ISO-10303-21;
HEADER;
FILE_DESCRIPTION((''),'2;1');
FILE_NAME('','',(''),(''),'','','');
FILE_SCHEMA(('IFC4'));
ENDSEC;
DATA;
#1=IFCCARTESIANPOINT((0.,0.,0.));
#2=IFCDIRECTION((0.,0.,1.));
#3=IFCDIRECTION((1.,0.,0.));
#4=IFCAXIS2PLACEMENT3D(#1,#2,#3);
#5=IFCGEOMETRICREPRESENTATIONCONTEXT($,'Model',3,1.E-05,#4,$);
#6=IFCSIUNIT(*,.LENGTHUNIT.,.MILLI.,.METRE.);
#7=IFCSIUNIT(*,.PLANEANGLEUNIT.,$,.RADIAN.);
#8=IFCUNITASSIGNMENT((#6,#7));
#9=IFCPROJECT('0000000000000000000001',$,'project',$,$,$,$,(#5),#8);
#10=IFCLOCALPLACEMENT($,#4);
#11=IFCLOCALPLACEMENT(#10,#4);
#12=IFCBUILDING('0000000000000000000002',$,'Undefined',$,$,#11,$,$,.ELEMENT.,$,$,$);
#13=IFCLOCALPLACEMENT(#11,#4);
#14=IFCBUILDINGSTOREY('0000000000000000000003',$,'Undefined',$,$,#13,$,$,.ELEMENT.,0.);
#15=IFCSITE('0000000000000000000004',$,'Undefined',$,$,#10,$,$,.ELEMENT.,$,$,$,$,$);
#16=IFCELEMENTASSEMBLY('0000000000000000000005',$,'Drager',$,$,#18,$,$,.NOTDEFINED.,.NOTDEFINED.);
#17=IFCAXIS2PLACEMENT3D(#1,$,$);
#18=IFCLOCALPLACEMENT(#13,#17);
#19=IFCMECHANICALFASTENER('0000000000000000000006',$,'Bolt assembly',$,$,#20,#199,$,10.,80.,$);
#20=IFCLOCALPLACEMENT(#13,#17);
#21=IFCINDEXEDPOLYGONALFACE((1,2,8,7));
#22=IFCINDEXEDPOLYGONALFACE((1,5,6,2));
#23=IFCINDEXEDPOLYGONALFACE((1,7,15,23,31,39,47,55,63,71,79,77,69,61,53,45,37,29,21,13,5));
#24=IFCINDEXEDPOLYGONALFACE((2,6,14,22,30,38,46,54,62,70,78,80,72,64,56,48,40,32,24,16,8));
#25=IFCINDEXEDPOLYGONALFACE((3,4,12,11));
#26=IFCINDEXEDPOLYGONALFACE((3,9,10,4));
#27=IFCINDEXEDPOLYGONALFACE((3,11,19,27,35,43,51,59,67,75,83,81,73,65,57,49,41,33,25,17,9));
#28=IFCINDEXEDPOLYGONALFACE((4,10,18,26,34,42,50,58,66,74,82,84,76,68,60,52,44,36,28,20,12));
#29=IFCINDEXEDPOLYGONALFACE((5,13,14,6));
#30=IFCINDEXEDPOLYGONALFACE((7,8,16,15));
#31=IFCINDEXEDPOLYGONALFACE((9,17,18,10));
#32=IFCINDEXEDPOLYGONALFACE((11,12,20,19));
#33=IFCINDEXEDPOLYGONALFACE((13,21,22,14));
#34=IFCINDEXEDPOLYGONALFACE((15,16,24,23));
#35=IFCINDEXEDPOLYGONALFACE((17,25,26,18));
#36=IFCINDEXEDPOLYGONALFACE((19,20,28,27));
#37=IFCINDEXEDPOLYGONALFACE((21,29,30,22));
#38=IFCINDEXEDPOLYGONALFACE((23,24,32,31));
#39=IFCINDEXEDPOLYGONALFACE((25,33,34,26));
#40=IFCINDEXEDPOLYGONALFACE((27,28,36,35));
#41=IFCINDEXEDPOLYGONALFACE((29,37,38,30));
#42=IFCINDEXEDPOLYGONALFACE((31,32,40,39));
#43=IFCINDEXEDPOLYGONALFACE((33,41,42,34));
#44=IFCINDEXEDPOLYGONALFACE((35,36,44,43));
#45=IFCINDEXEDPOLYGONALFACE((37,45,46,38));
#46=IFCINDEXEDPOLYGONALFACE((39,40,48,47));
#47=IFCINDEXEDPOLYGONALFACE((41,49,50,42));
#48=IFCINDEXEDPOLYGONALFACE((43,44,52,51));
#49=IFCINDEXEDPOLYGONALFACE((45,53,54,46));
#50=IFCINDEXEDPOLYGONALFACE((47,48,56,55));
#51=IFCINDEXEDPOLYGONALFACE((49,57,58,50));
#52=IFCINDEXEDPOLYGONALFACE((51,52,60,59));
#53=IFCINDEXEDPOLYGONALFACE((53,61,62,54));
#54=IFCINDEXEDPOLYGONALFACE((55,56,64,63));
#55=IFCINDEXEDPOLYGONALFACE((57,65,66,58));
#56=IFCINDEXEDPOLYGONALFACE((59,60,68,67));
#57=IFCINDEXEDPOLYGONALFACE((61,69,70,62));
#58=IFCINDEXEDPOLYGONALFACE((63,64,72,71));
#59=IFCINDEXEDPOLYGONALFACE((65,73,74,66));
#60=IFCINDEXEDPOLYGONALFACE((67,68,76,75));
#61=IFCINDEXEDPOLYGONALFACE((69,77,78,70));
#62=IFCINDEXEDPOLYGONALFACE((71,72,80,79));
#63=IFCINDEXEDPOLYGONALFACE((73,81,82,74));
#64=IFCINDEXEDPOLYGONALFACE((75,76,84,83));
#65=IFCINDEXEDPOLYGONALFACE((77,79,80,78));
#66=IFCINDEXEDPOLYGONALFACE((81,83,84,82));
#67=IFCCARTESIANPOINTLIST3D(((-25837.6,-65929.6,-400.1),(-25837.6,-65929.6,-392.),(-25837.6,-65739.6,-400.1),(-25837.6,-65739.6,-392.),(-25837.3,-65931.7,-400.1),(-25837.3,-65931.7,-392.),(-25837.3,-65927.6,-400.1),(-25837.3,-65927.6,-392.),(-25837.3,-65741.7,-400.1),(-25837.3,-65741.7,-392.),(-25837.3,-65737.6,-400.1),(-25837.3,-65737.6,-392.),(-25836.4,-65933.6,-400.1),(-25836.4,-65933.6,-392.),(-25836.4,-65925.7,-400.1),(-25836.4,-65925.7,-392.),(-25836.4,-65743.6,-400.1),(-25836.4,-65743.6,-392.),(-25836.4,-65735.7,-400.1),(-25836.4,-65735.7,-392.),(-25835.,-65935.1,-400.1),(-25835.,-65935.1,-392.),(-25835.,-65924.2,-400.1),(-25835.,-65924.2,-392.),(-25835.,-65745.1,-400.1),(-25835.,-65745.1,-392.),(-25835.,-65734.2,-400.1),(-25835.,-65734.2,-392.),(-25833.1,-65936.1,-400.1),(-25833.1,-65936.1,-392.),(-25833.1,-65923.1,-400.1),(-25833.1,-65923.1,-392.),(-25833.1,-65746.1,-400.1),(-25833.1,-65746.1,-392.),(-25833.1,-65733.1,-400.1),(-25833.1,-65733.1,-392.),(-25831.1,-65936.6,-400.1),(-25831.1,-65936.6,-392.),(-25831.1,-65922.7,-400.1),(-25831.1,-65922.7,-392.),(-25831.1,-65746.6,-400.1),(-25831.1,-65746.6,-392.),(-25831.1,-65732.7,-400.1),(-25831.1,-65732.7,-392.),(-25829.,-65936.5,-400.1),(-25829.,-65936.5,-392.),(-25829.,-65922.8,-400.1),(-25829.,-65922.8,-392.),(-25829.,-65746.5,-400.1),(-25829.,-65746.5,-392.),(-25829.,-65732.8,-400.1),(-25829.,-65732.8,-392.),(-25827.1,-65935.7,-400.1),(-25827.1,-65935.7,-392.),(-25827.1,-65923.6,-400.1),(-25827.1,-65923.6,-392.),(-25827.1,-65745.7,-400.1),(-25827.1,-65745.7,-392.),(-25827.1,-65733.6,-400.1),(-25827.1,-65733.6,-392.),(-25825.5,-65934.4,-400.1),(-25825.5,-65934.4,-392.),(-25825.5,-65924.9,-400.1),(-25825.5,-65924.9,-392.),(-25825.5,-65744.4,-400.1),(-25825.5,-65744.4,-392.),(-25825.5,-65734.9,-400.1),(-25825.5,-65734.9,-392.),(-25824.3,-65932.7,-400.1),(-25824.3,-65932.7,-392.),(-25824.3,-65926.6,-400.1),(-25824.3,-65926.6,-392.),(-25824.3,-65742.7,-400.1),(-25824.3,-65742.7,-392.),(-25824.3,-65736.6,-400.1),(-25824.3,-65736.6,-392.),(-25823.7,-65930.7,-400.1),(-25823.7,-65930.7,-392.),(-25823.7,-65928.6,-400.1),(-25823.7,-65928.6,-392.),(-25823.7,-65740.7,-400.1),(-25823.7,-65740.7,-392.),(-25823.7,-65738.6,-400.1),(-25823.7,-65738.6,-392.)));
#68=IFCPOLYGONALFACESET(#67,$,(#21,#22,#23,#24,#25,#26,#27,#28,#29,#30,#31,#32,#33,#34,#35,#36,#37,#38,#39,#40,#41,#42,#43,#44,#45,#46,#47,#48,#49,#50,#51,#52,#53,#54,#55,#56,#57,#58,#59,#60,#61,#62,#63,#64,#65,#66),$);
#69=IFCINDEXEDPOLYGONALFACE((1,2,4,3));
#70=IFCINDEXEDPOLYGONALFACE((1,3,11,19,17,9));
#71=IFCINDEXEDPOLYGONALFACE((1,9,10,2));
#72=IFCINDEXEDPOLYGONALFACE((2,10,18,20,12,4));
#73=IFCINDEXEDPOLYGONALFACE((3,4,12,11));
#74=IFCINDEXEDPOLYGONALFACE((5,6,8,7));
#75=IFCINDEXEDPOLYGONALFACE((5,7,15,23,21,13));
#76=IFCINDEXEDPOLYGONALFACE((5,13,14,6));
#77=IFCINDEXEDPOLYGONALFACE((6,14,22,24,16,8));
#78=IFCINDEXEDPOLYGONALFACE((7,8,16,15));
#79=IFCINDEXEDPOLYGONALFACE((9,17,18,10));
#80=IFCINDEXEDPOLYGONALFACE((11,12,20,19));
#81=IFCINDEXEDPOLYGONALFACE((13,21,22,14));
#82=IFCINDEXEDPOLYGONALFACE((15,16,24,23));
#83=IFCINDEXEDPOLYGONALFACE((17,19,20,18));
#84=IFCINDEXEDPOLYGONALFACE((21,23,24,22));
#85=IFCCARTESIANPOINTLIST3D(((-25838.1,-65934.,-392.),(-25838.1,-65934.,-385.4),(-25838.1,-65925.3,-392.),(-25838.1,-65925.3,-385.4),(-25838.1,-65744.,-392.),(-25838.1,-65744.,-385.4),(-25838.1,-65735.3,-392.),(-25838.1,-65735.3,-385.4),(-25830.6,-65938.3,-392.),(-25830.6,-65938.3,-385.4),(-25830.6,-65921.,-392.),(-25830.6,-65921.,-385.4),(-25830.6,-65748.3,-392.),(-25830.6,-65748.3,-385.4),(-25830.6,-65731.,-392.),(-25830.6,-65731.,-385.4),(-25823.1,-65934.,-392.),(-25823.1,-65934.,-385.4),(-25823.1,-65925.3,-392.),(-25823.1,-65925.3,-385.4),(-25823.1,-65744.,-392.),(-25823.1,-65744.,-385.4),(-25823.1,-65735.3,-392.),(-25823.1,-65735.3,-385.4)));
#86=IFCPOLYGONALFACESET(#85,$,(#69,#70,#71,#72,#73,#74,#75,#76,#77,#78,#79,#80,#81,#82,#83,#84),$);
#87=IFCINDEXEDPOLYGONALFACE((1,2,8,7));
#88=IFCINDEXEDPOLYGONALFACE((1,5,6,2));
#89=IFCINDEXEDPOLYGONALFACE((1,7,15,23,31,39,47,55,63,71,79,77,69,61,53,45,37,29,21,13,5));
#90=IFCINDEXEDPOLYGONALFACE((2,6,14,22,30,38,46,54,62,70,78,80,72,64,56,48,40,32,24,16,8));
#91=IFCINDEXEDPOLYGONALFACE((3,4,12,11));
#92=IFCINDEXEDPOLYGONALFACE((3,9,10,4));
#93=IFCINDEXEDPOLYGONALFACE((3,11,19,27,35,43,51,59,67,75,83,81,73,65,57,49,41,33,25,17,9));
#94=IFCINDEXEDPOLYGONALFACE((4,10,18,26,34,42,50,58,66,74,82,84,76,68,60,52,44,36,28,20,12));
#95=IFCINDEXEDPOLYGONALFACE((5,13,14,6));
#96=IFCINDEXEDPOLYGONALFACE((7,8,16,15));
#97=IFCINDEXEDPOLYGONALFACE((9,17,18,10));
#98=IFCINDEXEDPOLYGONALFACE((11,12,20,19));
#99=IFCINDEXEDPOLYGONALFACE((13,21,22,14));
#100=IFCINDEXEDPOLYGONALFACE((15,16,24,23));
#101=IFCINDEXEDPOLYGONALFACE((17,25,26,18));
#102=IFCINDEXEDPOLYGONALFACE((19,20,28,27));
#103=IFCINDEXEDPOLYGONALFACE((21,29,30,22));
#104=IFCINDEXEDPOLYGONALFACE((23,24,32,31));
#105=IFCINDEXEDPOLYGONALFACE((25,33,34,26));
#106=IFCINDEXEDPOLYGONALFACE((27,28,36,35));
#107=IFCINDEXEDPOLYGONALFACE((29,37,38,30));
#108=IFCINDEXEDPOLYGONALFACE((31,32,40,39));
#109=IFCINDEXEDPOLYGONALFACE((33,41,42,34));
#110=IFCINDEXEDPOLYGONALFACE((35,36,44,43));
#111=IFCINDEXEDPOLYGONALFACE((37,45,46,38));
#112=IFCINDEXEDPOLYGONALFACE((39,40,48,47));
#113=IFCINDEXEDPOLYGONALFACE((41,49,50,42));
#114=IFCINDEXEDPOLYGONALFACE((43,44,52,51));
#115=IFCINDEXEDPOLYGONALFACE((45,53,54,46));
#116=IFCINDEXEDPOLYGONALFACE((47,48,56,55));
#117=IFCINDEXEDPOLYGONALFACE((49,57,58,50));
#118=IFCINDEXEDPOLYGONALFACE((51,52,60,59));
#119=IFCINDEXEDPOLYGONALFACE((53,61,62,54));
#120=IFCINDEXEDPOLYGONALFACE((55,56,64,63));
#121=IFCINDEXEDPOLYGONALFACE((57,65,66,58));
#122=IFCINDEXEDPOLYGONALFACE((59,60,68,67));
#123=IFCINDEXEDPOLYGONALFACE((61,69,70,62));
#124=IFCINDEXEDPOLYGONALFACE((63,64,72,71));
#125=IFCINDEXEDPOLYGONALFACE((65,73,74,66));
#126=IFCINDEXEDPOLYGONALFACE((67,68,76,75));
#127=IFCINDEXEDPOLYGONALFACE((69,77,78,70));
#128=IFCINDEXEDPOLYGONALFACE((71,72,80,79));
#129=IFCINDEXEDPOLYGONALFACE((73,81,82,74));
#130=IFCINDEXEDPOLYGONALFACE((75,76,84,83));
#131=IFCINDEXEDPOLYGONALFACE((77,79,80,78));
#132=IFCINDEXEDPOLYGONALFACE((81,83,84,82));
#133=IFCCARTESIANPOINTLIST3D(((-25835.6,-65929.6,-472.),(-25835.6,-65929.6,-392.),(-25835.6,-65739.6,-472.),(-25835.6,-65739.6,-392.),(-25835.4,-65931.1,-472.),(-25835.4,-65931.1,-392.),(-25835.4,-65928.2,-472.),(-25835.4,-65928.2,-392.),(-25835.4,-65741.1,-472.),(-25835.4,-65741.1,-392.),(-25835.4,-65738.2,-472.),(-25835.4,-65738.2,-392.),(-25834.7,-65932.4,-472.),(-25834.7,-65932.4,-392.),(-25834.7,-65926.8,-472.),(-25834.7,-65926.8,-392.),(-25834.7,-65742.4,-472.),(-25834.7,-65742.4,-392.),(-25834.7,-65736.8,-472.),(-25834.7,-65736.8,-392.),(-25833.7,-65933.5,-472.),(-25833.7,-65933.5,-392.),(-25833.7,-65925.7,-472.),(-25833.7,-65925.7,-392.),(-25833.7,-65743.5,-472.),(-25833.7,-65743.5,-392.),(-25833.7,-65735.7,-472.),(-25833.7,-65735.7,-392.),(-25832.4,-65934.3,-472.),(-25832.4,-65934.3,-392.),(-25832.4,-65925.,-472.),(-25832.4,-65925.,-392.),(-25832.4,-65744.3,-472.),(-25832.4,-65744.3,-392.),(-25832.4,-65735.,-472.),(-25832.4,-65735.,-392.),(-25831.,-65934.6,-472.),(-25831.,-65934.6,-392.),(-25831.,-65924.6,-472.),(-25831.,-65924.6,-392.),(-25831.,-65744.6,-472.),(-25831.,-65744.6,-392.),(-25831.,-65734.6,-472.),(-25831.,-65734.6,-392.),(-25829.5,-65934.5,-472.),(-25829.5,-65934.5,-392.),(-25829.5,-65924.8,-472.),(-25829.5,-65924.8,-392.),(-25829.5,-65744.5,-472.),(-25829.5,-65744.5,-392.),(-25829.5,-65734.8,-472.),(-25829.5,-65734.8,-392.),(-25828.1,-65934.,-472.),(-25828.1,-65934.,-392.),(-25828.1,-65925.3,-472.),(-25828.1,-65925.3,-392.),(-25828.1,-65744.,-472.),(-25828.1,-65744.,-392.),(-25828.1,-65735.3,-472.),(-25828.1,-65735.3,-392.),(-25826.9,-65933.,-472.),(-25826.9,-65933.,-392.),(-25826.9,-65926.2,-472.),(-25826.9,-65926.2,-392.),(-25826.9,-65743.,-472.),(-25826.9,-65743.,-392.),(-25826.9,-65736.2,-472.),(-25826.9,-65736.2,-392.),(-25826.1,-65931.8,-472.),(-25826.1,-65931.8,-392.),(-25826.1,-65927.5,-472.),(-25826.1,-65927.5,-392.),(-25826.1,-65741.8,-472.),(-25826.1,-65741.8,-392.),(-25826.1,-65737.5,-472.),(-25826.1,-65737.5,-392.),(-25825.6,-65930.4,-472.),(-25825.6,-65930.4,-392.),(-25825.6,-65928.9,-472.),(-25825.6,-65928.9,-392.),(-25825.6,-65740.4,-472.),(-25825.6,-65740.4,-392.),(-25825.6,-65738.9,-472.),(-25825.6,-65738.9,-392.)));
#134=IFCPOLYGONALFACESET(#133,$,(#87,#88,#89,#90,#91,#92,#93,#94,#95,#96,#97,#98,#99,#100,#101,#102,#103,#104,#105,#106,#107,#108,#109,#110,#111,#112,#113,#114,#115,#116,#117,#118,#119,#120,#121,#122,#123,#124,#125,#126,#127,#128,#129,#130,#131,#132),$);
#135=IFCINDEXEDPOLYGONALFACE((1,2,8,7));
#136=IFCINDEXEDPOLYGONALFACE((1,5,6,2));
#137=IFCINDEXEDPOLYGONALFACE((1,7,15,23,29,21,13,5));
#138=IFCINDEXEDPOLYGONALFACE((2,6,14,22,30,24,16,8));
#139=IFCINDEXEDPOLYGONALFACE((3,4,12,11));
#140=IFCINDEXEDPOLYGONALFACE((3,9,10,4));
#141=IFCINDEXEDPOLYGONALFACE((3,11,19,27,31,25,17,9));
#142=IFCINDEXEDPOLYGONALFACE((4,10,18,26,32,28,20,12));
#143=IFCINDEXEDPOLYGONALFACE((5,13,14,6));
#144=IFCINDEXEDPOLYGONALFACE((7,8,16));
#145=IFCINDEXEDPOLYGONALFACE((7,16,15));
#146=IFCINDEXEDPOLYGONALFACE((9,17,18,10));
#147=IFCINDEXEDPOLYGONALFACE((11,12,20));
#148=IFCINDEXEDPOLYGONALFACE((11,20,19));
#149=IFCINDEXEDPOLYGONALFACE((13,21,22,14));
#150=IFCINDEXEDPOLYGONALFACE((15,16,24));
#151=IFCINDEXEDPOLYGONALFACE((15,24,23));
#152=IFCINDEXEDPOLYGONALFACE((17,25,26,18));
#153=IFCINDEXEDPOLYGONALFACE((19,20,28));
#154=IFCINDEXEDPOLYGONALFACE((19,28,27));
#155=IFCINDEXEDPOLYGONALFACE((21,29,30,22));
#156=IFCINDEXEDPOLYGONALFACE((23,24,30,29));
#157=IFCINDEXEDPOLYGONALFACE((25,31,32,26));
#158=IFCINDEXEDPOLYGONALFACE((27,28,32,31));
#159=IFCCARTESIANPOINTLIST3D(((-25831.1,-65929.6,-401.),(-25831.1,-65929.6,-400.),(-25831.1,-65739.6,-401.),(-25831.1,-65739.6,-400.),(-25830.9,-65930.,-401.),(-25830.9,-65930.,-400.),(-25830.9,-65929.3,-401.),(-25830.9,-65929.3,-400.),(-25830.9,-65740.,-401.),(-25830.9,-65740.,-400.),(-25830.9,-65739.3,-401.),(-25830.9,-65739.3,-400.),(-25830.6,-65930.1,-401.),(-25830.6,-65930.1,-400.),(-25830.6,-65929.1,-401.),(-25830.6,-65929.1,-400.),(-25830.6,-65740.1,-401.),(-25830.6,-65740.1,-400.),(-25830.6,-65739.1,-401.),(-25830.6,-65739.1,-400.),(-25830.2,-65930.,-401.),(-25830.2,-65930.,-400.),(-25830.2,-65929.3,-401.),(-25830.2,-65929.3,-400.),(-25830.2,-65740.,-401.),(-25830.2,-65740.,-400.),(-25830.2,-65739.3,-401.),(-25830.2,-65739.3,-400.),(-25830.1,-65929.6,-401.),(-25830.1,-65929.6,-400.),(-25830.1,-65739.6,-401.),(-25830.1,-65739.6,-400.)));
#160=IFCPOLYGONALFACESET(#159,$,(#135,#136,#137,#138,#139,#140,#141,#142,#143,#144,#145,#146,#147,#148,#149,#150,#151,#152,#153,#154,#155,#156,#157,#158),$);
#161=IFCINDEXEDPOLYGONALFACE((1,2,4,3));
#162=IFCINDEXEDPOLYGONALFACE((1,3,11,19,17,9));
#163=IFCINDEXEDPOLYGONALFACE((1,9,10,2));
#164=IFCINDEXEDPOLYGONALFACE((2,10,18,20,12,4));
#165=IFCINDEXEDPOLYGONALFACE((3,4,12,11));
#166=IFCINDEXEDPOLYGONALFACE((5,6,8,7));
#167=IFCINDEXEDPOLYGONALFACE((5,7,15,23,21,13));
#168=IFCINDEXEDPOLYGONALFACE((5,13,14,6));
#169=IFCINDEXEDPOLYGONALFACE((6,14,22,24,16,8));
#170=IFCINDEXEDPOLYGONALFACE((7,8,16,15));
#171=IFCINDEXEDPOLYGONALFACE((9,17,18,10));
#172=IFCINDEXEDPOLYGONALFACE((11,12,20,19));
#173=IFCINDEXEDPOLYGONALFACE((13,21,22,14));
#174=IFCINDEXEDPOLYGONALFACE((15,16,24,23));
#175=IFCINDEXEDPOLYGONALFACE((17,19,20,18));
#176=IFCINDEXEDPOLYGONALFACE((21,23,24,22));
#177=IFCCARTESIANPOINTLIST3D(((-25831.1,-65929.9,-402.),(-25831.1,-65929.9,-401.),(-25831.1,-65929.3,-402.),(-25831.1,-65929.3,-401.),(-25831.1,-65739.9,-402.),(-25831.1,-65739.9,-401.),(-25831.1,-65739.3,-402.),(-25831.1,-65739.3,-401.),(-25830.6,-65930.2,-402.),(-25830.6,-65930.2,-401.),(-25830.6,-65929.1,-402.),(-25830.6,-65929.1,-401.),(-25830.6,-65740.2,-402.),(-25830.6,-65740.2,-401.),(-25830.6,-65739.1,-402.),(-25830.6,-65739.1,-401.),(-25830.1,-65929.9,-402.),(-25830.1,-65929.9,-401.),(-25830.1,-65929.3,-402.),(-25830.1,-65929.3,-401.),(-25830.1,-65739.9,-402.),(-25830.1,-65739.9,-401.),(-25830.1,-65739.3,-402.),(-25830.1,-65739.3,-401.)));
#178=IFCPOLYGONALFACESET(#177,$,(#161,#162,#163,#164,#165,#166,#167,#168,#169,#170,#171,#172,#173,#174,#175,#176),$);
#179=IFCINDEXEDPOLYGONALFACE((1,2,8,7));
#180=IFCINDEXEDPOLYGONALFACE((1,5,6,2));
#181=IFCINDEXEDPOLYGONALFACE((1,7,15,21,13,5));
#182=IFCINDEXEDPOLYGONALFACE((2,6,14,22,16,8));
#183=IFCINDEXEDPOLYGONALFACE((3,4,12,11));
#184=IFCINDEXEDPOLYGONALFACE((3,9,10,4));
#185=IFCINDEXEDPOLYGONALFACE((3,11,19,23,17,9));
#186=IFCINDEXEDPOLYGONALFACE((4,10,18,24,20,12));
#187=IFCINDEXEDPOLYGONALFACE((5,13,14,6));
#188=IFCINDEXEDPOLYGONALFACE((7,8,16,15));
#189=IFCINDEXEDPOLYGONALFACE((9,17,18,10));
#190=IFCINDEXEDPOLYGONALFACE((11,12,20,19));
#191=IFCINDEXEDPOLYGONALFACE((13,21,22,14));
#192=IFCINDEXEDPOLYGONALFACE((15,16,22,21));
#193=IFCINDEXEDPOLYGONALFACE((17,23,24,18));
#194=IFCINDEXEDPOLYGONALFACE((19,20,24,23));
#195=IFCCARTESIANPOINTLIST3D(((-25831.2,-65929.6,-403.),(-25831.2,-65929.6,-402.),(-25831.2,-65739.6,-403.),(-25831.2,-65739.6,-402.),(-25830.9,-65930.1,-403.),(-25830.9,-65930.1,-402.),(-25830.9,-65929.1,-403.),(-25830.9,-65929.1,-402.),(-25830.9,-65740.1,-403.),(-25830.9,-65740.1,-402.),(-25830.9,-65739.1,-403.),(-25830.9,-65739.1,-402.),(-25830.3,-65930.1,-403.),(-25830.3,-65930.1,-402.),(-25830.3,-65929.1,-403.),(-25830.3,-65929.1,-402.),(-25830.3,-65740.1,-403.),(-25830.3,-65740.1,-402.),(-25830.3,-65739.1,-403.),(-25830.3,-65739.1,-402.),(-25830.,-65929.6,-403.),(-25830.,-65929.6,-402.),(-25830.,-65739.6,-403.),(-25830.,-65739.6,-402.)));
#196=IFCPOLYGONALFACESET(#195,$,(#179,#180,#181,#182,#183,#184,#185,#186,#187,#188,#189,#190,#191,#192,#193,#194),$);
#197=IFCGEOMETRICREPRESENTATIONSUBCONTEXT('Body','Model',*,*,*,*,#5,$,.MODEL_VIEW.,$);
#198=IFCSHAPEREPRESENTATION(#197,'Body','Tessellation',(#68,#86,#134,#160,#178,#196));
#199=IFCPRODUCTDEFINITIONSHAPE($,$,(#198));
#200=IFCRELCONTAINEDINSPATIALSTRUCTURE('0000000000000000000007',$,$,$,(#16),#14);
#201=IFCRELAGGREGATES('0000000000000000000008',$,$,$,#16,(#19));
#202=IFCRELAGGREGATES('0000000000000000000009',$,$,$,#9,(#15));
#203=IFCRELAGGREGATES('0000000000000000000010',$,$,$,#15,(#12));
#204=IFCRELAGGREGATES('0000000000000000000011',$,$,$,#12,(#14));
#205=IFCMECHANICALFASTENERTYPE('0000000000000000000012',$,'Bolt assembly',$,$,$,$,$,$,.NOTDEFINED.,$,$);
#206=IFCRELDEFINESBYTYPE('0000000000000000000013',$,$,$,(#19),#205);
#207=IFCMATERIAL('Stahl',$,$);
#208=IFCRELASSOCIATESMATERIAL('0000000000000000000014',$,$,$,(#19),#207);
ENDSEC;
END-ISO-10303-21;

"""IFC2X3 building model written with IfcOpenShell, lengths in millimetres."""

from ifc_helpers import new_model, si_unit, frame, origin_with_axes, origin_2d_with_axis, place, context, subcontext, project, spatial, polyline, circle, outline, extrude, source, transform, mapped, material, type_object, element, aggregate, save


model = new_model("IFC2X3")

# Units and contexts
model_context = context("Model", 3, precision=1e-05, world=origin_with_axes())
body_context = subcontext(model_context, "Body", "Model", "MODEL_VIEW")
ifc_project = project(units=[si_unit("LENGTHUNIT", "METRE", prefix="MILLI"), si_unit("PLANEANGLEUNIT", "RADIAN")], contexts=[model_context])

# Site, building, storey
site_placement = place(None, origin_with_axes())
site = spatial("IfcSite", under=ifc_project, at=site_placement, Name="Undefined", CompositionType="ELEMENT")
building_placement = place(site_placement, origin_with_axes())
building = spatial("IfcBuilding", under=site, at=building_placement, Name="Undefined", CompositionType="ELEMENT")
storey_placement = place(building_placement, origin_with_axes())
storey = spatial("IfcBuildingStorey", under=building, at=storey_placement, Name="Undefined", CompositionType="ELEMENT", Elevation=0.0)

# Element assembly
assembly_1_placement = place(storey_placement, origin_with_axes())
assembly_1 = element("IfcElementAssembly", 1, at=assembly_1_placement, inside=storey, Name="Drager", AssemblyPlace="NOTDEFINED", PredefinedType="NOTDEFINED")

# Mechanical fastener
mechanical_fastener_type = type_object("IfcMechanicalFastenerType", Name="Bolt assembly")
ifc_material_1 = material(Name="Stahl")
shared_shape_1 = source(origin_with_axes(), body_context, "Body", "SweptSolid", [
    extrude(circle(Radius=7.0, at=origin_2d_with_axis()), frame((0.0, 0.0, 0.0), z_axis=(0.0, 1.0, 0.0), x_axis=(1.0, 0.0, 0.0)), (0.0, 0.0, 1.0), 8.1),
    extrude(outline(polyline([(7.5, -4.3), (7.5, 4.3), (0.0, 8.7), (-7.5, 4.3), (-7.5, -4.3), (0.0, -8.7), (7.5, -4.3)])), frame((0.0, -6.6, 0.0), z_axis=(0.0, 1.0, 0.0), x_axis=(1.0, 0.0, 0.0)), (0.0, 0.0, 1.0), 6.6),
    extrude(circle(Radius=5.0, at=origin_2d_with_axis()), frame((0.0, 0.0, 0.0), z_axis=(0.0, 1.0, 0.0), x_axis=(1.0, 0.0, 0.0)), (0.0, 0.0, 1.0), 80.0),
    extrude(circle(Radius=0.5, at=origin_2d_with_axis()), frame((0.0, 8.0, 0.0), z_axis=(0.0, 1.0, 0.0), x_axis=(1.0, 0.0, 0.0)), (0.0, 0.0, 1.0), 1.0),
    extrude(outline(polyline([(0.5, -0.3), (0.5, 0.3), (0.0, 0.6), (-0.5, 0.3), (-0.5, -0.3), (0.0, -0.6), (0.5, -0.3)])), frame((0.0, 9.0, 0.0), z_axis=(0.0, 1.0, 0.0), x_axis=(1.0, 0.0, 0.0)), (0.0, 0.0, 1.0), 1.0),
    extrude(outline(polyline([(0.6, 0.0), (0.3, 0.5), (-0.3, 0.5), (-0.6, 0.0), (-0.3, -0.5), (0.3, -0.5), (0.6, 0.0)])), frame((0.0, 10.0, 0.0), z_axis=(0.0, 1.0, 0.0), x_axis=(1.0, 0.0, 0.0)), (0.0, 0.0, 1.0), 1.0),
])
mechanical_fastener_1_placement = place(assembly_1_placement, frame((-25830.6, -65834.6, -392.0), z_axis=(0.0, -1.0, 0.0), x_axis=(-1.0, 0.0, 0.0)))
mechanical_fastener_1 = element("IfcMechanicalFastener", 2, at=mechanical_fastener_1_placement, type_object=mechanical_fastener_type, material=ifc_material_1, Name="Bolt assembly", NominalDiameter=10.0, NominalLength=80.0, context=body_context, shape_type="MappedRepresentation", body=[
    mapped(shared_shape_1, transform((0.0, 0.0, -95.0))),
    mapped(shared_shape_1, transform((0.0, 0.0, 95.0))),
])
aggregate(assembly_1, [mechanical_fastener_1])

save(model, "model.ifc")
